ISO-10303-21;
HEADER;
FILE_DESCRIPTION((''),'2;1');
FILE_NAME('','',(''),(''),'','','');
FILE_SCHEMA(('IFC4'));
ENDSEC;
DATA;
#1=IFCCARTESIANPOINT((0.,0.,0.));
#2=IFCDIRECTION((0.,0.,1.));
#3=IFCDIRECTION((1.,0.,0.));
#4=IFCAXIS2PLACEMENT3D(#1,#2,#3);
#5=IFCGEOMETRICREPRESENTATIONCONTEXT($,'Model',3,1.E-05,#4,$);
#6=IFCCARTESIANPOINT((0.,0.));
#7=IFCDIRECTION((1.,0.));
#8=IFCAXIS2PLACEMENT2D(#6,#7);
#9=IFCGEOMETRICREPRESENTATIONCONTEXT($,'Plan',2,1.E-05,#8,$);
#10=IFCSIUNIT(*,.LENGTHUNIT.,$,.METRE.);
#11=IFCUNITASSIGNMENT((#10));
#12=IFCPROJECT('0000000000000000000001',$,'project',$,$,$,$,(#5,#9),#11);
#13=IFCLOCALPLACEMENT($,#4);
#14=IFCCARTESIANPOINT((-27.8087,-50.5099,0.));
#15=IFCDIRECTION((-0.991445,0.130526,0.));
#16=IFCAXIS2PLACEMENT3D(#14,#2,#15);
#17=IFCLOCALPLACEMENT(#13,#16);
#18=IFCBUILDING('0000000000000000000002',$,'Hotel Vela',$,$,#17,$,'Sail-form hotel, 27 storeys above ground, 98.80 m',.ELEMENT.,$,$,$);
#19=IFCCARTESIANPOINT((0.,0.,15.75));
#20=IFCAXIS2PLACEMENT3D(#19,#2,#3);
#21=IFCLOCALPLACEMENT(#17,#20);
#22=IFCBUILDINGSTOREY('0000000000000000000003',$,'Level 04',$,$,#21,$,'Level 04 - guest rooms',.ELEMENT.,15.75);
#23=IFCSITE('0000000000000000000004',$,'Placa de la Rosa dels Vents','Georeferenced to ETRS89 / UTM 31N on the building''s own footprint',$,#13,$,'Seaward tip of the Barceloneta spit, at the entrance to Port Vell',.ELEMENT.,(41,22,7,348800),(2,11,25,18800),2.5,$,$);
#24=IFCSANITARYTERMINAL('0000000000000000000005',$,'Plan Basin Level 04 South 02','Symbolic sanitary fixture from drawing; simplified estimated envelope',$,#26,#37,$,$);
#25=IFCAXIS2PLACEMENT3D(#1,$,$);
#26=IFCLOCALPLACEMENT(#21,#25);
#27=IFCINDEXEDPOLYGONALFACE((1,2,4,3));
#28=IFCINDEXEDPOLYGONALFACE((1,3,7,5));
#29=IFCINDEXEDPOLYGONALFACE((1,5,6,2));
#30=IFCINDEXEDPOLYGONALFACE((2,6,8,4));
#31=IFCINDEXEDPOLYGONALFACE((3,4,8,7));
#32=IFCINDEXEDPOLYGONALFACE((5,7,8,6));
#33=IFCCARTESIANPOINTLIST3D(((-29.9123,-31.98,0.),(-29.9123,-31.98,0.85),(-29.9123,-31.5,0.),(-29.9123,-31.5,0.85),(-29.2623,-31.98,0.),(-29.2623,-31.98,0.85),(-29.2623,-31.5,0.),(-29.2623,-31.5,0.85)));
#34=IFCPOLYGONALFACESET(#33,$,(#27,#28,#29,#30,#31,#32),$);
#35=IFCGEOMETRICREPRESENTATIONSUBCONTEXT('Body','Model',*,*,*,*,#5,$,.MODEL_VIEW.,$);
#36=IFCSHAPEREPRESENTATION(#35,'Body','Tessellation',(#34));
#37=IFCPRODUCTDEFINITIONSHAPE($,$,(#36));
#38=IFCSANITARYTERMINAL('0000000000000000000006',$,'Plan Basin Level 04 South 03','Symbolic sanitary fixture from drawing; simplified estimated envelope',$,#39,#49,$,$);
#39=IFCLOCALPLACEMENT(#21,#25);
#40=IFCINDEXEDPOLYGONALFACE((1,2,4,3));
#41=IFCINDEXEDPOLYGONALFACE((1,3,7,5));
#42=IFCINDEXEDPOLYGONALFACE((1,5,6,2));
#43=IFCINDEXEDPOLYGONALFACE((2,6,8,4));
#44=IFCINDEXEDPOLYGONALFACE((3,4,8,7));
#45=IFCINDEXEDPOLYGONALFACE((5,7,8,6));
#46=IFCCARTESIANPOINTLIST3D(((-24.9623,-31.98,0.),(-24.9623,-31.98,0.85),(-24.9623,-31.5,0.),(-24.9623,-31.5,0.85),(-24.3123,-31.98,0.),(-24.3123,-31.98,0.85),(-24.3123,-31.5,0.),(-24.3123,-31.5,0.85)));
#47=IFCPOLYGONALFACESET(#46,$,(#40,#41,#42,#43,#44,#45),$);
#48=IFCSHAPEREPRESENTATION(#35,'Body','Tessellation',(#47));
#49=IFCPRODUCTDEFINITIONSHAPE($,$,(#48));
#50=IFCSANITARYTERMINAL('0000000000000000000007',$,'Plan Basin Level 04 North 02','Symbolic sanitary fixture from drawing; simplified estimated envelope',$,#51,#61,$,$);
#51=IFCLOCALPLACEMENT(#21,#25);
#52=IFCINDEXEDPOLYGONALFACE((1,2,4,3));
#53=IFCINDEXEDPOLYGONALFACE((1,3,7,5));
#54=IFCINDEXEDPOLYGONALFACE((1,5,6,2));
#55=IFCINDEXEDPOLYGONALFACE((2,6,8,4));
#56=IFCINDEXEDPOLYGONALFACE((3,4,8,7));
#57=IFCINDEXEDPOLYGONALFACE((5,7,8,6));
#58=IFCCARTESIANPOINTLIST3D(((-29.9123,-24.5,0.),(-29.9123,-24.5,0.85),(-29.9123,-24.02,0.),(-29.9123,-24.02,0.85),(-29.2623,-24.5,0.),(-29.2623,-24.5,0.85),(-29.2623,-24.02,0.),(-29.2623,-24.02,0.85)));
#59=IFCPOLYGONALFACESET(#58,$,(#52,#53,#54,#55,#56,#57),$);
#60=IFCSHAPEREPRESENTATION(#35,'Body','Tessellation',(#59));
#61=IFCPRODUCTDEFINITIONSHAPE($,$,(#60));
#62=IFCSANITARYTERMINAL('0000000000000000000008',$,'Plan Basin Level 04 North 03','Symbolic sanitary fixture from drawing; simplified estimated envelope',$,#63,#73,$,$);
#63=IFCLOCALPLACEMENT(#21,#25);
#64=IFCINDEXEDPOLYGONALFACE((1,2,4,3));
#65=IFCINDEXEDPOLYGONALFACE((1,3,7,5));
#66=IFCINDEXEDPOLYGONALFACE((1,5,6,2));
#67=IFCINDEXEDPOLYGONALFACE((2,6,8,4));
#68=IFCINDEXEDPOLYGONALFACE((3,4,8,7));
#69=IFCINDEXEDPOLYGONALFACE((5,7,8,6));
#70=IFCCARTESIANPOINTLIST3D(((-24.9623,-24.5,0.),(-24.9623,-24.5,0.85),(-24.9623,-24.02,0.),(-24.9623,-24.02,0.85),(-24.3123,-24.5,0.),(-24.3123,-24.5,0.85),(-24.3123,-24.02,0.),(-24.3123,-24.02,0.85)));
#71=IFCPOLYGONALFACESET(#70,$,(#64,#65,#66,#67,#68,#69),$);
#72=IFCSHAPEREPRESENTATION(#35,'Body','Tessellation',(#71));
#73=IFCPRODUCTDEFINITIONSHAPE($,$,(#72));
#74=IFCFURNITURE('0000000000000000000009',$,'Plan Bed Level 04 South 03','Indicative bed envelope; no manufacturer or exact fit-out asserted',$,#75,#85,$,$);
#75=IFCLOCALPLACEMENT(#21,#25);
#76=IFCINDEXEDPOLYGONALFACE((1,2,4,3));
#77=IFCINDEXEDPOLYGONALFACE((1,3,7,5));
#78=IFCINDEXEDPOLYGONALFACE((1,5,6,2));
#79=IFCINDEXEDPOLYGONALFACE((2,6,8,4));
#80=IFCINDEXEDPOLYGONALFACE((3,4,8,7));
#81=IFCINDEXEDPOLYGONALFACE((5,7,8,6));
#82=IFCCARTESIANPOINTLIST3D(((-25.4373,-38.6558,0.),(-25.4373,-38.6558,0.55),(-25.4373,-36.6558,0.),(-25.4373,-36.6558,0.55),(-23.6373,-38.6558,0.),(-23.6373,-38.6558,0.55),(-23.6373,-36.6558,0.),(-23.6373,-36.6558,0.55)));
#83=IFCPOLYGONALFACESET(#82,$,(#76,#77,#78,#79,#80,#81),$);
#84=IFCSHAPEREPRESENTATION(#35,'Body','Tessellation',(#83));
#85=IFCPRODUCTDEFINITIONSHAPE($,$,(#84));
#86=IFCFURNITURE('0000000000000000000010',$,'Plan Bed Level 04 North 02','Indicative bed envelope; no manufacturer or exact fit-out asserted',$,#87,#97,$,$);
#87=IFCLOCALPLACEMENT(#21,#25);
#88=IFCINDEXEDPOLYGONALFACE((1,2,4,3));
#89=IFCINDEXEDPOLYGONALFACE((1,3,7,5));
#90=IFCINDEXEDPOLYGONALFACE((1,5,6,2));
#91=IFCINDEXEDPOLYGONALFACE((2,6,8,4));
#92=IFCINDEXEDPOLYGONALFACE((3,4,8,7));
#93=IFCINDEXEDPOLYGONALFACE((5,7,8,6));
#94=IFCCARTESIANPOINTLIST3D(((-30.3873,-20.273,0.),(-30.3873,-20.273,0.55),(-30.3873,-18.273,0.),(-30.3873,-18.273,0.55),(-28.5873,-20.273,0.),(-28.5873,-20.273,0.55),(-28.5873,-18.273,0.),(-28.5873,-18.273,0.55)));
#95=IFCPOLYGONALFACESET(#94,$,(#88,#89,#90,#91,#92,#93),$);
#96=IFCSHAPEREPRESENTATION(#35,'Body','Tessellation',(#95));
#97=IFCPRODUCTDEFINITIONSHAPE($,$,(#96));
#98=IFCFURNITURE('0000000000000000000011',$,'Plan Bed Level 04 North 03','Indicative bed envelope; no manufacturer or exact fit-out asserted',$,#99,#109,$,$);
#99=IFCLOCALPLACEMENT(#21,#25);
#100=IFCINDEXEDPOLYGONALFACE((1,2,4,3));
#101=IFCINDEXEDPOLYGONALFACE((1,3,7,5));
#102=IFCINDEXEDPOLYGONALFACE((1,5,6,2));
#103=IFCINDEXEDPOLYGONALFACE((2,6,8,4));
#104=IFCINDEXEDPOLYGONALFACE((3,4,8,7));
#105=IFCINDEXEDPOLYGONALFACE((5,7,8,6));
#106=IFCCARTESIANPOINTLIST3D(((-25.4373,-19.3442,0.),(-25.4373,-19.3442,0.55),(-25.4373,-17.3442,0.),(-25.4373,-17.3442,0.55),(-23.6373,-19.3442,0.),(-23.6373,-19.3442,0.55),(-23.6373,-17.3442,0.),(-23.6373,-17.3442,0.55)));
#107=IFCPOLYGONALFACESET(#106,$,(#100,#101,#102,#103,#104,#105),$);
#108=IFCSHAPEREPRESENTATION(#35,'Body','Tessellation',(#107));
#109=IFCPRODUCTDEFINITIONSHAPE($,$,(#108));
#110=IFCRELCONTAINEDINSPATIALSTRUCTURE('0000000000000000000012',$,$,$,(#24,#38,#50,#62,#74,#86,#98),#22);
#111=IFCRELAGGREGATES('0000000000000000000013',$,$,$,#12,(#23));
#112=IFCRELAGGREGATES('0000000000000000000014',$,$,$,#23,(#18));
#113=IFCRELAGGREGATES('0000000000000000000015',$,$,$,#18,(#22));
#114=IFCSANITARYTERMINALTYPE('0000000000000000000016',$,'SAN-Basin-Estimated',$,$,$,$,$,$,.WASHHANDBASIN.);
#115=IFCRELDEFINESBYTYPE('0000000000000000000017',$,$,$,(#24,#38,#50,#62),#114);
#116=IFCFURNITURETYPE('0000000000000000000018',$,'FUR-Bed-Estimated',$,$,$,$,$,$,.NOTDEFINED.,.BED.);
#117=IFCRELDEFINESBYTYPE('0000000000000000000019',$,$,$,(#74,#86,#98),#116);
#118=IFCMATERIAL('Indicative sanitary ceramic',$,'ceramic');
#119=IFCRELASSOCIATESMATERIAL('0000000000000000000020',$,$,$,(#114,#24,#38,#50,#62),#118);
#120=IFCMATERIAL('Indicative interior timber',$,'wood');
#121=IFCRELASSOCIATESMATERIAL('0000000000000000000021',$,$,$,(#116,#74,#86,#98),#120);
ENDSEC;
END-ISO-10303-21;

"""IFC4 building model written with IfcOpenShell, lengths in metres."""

from ifc_helpers import new_model, si_unit, frame, origin_with_axes, origin_2d_with_axis, place, context, subcontext, project, spatial, line, indexed_curve, outline, extrude, material, type_object, element, save


model = new_model("IFC4")

# Units and contexts
model_context = context("Model", 3, precision=1e-05, world=origin_with_axes())
plan_context = context("Plan", 2, precision=1e-05, world=origin_2d_with_axis())
body_context = subcontext(model_context, "Body", "Model", "MODEL_VIEW")
ifc_project = project(units=[si_unit("LENGTHUNIT", "METRE")], contexts=[model_context, plan_context])

# Site, building, storey
site_placement = place(None, origin_with_axes())
site = spatial("IfcSite", under=ifc_project, at=site_placement, Name="Placa de la Rosa dels Vents", Description="Georeferenced to ETRS89 / UTM 31N on the building's own footprint", LongName="Seaward tip of the Barceloneta spit, at the entrance to Port Vell", CompositionType="ELEMENT", RefLatitude=(41, 22, 7, 348800), RefLongitude=(2, 11, 25, 18800), RefElevation=2.5)
building_placement = place(site_placement, frame((-27.8087, -50.5099, 0.0), z_axis=(0.0, 0.0, 1.0), x_axis=(-0.991445, 0.130526, 0.0)))
building = spatial("IfcBuilding", under=site, at=building_placement, Name="Hotel Vela", LongName="Sail-form hotel, 27 storeys above ground, 98.80 m", CompositionType="ELEMENT")
storey_placement = place(building_placement, frame((0.0, 0.0, 15.75), z_axis=(0.0, 0.0, 1.0), x_axis=(1.0, 0.0, 0.0)))
storey = spatial("IfcBuildingStorey", under=building, at=storey_placement, Name="Level 04", LongName="Level 04 - guest rooms", CompositionType="ELEMENT", Elevation=15.75)

# Shared definitions
ifc_material_1 = material(Name="Indicative interior timber", Category="wood")

# Sanitary terminals
ifc_material_2 = material(Name="Indicative sanitary ceramic", Category="ceramic")
sanitary_terminal_type_1 = type_object("IfcSanitaryTerminalType", Name="SAN-Basin-Estimated", PredefinedType="WASHHANDBASIN", material=ifc_material_2)
for number, where, z_axis, x_axis, name in (
    (1, (-29.9123, -31.98, 0.0), (0.0, 0.0, 1.0), (1.0, 0.0, 0.0), "Plan Basin Level 04 South 02"),
    (2, (-24.9623, -31.98, 0.0), (0.0, 0.0, 1.0), (1.0, 0.0, 0.0), "Plan Basin Level 04 South 03"),
    (3, (-29.9123, -24.5, 0.0), (0.0, 0.0, 1.0), (1.0, 0.0, 0.0), "Plan Basin Level 04 North 02"),
    (4, (-24.9623, -24.5, 0.0), (0.0, 0.0, 1.0), (1.0, 0.0, 0.0), "Plan Basin Level 04 North 03"),
):
    element("IfcSanitaryTerminal", number, at=place(storey_placement, frame(where, z_axis=z_axis, x_axis=x_axis)), inside=storey, type_object=sanitary_terminal_type_1, material=ifc_material_2, Name=name, Description="Symbolic sanitary fixture from drawing; simplified estimated envelope", context=body_context, shape_type="SweptSolid", body=[
        extrude(outline(indexed_curve([(0.0, 0.0), (0.65, 0.0), (0.65, 0.48), (0.0, 0.48)], segments=[line(1, 2, 3, 4, 1)])), origin_with_axes(), (0.0, 0.0, 1.0), 0.85),
    ])

# Furniture
furniture_type = type_object("IfcFurnitureType", Name="FUR-Bed-Estimated", AssemblyPlace="NOTDEFINED", PredefinedType="BED", material=ifc_material_1)
for number, where, z_axis, x_axis, name in (
    (5, (-25.4373, -38.6558, 0.0), (0.0, 0.0, 1.0), (1.0, 0.0, 0.0), "Plan Bed Level 04 South 03"),
    (6, (-30.3873, -20.273, 0.0), (0.0, 0.0, 1.0), (1.0, 0.0, 0.0), "Plan Bed Level 04 North 02"),
    (7, (-25.4373, -19.3442, 0.0), (0.0, 0.0, 1.0), (1.0, 0.0, 0.0), "Plan Bed Level 04 North 03"),
):
    element("IfcFurniture", number, at=place(storey_placement, frame(where, z_axis=z_axis, x_axis=x_axis)), inside=storey, type_object=furniture_type, material=ifc_material_1, Name=name, Description="Indicative bed envelope; no manufacturer or exact fit-out asserted", context=body_context, shape_type="SweptSolid", body=[
        extrude(outline(indexed_curve([(0.0, 0.0), (1.8, 0.0), (1.8, 2.0), (0.0, 2.0)], segments=[line(1, 2, 3, 4, 1)])), origin_with_axes(), (0.0, 0.0, 1.0), 0.55),
    ])

save(model, "model.ifc")
